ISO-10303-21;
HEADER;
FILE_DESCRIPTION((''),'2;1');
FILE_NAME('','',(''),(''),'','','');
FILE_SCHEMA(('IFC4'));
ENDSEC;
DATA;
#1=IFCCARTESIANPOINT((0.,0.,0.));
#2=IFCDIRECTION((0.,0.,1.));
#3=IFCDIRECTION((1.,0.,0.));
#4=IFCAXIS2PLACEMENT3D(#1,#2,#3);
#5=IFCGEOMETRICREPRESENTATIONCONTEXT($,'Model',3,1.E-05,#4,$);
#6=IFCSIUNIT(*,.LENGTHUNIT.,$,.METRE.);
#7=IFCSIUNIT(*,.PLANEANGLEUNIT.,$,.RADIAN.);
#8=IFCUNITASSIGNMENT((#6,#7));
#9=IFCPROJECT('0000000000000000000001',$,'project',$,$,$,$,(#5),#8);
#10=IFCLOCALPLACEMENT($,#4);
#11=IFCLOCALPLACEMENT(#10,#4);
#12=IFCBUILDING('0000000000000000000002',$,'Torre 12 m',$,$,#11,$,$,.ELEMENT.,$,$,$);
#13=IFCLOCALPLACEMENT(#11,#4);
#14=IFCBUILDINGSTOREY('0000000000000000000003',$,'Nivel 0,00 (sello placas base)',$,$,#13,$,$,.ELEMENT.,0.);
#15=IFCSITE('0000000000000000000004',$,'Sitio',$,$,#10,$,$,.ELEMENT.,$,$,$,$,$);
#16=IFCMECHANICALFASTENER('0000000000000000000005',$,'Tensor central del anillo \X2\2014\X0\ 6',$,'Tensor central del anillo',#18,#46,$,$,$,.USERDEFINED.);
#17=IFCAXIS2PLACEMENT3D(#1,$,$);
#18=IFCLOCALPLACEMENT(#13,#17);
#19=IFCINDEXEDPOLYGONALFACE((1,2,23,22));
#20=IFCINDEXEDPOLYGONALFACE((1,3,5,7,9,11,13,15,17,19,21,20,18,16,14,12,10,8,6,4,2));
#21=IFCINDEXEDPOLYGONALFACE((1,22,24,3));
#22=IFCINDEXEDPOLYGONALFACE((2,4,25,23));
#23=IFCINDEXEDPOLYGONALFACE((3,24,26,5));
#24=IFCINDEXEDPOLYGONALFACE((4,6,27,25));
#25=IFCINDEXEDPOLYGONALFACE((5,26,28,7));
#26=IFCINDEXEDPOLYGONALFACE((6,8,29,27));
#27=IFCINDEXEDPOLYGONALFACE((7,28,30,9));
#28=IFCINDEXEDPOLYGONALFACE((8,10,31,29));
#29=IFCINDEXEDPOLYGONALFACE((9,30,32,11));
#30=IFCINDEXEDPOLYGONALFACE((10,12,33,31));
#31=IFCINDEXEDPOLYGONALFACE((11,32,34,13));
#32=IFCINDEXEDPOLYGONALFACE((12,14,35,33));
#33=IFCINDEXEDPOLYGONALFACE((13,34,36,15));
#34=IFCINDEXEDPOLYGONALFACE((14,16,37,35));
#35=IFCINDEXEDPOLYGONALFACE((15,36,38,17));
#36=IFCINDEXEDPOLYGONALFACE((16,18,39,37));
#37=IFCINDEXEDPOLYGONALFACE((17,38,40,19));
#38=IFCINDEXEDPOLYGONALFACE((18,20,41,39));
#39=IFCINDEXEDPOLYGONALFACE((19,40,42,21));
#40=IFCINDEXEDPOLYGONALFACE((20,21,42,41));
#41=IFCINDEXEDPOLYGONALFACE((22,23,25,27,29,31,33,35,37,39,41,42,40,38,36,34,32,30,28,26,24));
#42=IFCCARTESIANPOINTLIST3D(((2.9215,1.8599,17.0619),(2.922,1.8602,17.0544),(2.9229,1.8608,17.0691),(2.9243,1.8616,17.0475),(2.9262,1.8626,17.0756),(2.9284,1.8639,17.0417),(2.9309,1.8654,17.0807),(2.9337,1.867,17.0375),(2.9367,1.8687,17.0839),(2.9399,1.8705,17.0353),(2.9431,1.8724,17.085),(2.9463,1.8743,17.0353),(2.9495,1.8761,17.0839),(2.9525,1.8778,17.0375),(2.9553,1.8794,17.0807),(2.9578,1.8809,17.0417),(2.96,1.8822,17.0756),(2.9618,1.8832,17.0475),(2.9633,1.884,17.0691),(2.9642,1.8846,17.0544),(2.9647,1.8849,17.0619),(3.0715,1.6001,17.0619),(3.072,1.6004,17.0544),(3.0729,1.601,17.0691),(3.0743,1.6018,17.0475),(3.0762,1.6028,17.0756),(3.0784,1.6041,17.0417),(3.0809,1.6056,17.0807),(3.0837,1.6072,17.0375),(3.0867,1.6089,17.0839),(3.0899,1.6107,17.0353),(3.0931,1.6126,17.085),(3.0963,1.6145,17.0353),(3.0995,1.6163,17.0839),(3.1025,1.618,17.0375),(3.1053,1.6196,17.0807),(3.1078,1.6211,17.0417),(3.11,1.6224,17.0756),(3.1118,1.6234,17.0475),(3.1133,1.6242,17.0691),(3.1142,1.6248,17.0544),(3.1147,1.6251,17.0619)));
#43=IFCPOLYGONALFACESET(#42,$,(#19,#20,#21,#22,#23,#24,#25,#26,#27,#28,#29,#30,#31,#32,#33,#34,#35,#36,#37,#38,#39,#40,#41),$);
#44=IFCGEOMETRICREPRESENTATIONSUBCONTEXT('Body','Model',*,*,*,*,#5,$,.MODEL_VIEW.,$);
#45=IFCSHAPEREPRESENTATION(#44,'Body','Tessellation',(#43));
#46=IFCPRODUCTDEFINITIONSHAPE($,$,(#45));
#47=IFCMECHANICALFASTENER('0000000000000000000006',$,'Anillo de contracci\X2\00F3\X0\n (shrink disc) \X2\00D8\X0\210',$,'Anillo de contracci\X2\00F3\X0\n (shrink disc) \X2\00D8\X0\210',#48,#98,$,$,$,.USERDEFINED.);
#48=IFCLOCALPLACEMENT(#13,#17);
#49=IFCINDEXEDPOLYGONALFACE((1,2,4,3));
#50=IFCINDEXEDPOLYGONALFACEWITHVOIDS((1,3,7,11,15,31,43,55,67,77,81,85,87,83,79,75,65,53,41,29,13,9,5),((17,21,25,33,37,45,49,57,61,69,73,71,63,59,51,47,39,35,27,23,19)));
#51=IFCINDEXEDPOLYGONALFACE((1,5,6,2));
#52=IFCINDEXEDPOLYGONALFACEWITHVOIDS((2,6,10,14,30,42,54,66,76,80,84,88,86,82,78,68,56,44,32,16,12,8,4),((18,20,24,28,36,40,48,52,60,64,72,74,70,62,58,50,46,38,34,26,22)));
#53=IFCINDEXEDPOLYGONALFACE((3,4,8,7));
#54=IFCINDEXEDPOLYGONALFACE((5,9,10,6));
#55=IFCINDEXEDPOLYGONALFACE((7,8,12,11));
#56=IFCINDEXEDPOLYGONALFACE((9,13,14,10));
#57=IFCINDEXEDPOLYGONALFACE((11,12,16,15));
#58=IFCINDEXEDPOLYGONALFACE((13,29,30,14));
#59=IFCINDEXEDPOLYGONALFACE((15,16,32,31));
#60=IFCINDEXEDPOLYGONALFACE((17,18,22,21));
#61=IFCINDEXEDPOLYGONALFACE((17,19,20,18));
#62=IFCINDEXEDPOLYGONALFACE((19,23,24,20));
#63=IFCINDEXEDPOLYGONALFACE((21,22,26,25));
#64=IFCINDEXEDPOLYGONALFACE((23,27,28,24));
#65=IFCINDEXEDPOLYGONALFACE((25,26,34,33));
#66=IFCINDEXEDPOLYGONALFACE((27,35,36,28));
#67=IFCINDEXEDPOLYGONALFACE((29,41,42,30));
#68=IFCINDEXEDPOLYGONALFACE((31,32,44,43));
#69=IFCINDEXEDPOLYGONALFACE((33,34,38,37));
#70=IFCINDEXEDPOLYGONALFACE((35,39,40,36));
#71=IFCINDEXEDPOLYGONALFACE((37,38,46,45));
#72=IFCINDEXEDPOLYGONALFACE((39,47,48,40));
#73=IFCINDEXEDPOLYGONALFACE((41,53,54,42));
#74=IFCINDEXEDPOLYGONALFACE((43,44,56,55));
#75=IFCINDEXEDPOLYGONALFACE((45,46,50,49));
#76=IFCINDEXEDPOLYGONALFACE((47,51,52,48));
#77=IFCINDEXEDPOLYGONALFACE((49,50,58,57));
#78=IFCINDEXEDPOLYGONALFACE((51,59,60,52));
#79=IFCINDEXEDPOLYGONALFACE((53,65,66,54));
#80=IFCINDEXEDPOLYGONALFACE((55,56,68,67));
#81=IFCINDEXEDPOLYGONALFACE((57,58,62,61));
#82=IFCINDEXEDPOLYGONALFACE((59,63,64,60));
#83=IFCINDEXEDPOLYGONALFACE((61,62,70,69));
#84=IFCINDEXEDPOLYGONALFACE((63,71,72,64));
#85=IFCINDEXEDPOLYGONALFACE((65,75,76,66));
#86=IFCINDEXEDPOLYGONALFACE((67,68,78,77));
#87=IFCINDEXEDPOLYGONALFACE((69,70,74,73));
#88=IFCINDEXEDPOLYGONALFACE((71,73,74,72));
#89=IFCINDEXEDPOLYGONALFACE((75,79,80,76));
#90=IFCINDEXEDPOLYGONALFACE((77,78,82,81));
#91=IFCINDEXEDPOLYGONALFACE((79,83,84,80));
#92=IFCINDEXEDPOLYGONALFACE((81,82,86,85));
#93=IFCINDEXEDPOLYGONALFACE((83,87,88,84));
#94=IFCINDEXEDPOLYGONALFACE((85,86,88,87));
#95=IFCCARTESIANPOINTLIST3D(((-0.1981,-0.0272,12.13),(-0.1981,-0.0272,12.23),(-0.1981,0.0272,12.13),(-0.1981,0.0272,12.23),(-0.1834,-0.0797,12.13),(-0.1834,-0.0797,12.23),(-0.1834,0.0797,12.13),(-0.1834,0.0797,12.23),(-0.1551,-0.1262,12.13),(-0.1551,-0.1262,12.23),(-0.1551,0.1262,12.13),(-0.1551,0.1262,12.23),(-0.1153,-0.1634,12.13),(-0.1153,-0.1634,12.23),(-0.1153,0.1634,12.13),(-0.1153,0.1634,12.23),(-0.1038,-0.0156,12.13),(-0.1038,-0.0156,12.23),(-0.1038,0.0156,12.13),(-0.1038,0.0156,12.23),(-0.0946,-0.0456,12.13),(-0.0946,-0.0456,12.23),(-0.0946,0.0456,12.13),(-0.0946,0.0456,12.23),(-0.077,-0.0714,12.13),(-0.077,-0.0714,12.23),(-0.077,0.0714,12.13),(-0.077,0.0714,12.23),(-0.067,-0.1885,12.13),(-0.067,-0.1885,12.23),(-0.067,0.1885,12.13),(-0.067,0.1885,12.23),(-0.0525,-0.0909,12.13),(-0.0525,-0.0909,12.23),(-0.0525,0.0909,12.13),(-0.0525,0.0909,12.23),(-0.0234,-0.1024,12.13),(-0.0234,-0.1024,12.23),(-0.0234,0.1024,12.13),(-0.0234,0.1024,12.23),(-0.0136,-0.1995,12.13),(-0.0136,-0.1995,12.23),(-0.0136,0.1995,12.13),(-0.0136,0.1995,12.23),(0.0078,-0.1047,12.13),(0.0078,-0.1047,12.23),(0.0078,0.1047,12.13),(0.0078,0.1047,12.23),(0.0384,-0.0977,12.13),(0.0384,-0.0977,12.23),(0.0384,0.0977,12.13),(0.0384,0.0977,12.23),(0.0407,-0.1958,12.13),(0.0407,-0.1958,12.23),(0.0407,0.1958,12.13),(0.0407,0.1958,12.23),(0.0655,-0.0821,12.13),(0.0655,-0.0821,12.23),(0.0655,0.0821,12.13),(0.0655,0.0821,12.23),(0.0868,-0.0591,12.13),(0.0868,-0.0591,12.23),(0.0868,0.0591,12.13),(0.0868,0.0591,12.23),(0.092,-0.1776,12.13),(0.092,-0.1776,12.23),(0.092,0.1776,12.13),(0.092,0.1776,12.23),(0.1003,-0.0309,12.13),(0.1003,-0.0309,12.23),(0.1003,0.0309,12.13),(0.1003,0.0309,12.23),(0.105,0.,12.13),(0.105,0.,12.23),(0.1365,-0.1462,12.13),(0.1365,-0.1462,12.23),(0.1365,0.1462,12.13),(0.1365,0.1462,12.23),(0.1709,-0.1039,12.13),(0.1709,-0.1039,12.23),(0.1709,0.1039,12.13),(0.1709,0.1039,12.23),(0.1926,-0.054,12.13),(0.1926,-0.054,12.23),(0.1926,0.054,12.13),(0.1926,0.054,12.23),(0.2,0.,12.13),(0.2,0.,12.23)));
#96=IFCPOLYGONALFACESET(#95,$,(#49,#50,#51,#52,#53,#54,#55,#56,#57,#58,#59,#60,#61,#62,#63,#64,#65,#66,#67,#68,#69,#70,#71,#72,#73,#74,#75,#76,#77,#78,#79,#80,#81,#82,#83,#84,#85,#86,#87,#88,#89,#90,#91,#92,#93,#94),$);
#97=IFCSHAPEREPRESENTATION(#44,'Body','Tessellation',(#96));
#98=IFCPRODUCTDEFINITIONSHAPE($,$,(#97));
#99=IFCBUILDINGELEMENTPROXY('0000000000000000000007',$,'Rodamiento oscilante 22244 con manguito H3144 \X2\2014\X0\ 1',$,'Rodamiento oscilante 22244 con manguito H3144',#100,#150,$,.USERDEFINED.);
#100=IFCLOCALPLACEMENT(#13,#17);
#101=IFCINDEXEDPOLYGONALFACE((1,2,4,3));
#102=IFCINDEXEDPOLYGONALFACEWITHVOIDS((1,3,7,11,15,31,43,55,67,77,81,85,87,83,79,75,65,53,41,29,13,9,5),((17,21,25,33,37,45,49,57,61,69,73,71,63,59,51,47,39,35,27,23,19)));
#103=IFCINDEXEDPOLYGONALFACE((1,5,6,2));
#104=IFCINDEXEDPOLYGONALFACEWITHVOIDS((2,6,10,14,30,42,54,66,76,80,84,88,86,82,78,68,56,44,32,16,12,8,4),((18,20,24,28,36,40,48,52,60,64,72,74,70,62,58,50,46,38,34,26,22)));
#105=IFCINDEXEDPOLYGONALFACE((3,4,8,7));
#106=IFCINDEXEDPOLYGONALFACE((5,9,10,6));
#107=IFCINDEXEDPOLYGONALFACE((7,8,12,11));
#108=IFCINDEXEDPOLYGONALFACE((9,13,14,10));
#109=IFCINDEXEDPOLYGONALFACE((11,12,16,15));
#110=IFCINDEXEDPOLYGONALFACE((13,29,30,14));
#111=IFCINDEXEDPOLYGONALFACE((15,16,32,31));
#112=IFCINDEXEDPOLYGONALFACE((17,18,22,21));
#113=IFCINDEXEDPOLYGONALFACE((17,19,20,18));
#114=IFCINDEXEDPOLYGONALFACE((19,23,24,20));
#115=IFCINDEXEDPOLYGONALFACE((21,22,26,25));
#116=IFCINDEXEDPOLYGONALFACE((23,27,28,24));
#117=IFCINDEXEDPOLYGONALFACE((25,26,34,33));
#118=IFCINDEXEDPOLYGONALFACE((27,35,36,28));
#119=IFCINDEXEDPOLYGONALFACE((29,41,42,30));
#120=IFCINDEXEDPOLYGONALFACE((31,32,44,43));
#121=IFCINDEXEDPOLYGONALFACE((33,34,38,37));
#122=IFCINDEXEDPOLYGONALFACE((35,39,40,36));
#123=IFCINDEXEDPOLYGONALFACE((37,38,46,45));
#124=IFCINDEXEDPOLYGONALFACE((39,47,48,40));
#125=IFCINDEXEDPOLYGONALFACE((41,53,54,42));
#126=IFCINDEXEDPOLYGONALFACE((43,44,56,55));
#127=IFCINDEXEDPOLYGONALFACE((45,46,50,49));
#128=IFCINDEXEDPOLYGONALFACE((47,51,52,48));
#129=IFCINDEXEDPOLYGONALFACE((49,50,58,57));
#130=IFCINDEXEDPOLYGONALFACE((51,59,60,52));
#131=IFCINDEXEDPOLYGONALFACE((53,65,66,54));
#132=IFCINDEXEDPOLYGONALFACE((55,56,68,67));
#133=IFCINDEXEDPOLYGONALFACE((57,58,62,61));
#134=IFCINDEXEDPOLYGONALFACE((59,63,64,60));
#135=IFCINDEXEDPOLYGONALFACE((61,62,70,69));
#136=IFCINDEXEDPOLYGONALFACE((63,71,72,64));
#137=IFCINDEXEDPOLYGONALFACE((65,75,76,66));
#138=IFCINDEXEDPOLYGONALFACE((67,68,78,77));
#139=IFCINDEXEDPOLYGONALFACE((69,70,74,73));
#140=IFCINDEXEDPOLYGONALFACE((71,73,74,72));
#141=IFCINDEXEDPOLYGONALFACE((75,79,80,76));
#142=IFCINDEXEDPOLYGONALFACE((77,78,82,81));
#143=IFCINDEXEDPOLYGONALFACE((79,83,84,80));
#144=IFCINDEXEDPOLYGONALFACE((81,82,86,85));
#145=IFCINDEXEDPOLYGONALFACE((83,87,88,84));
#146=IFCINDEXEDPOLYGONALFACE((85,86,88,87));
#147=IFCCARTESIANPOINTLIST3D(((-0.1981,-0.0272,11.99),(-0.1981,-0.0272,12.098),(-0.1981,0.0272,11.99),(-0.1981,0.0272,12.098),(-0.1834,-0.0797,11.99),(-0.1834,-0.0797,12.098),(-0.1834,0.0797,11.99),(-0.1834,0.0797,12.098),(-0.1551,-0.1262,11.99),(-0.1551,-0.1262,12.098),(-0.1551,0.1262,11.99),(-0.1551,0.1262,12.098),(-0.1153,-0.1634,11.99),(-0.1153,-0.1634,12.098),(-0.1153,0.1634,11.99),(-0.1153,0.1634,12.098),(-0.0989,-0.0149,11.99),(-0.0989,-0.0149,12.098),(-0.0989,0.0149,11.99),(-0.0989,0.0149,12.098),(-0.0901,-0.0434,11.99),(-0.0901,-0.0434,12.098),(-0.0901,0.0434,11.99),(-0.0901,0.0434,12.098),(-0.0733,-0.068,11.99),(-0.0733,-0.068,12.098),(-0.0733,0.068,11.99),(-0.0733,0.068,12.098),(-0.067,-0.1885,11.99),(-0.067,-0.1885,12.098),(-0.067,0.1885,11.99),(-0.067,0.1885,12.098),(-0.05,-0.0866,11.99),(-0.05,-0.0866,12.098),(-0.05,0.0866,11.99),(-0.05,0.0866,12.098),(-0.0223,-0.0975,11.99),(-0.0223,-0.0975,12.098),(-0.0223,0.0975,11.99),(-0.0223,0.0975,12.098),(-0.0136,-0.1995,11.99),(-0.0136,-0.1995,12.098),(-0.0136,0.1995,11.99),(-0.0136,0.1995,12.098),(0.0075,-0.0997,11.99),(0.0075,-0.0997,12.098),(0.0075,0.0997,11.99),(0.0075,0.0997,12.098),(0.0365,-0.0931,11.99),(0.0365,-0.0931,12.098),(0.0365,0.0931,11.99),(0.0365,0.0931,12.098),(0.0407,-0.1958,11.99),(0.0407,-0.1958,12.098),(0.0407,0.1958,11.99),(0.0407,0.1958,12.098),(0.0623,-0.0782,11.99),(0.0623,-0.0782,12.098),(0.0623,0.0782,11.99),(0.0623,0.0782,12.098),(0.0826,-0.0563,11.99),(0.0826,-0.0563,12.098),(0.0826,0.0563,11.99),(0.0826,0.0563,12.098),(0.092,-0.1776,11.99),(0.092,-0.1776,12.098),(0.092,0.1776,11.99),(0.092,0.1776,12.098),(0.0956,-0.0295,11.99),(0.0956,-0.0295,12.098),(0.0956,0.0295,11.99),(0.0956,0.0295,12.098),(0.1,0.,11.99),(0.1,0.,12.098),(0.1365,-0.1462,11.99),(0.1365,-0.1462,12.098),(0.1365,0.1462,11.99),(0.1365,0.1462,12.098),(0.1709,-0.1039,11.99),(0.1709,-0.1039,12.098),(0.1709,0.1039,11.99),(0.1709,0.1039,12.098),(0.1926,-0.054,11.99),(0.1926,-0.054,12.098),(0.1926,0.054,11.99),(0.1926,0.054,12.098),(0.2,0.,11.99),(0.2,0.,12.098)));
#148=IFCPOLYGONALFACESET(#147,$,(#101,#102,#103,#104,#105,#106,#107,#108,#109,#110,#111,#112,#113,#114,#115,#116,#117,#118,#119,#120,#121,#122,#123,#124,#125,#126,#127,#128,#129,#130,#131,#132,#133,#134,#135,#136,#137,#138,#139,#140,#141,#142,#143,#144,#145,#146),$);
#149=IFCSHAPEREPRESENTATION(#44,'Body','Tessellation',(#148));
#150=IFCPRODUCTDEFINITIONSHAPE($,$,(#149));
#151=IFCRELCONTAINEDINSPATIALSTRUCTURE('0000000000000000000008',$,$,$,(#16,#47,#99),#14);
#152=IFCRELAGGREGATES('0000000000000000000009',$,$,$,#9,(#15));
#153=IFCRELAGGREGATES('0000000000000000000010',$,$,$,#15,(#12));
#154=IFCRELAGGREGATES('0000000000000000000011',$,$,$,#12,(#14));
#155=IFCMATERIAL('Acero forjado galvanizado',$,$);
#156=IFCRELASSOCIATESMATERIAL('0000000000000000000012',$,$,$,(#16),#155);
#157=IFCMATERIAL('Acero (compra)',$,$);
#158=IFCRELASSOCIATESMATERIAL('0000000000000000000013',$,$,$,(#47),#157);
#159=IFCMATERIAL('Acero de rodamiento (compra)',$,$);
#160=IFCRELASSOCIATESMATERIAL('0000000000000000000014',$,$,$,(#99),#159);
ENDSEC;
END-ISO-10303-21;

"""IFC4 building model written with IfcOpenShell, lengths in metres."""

from ifc_helpers import new_model, si_unit, frame, origin, origin_with_axes, origin_2d, place, context, subcontext, project, spatial, circle, hollow_circle, extrude, material, element, save


model = new_model("IFC4")

# Units and contexts
model_context = context("Model", 3, precision=1e-05, world=origin_with_axes())
body_context = subcontext(model_context, "Body", "Model", "MODEL_VIEW")
ifc_project = project(units=[si_unit("LENGTHUNIT", "METRE"), si_unit("PLANEANGLEUNIT", "RADIAN")], contexts=[model_context])

# Site, building, storey
site_placement = place(None, origin_with_axes())
site = spatial("IfcSite", under=ifc_project, at=site_placement, Name="Sitio", CompositionType="ELEMENT")
building_placement = place(site_placement, origin_with_axes())
building = spatial("IfcBuilding", under=site, at=building_placement, Name="Torre 12 m", CompositionType="ELEMENT")
storey_placement = place(building_placement, origin_with_axes())
storey = spatial("IfcBuildingStorey", under=building, at=storey_placement, Name="Nivel 0,00 (sello placas base)", CompositionType="ELEMENT", Elevation=0.0)

# Mechanical fasteners
ifc_material_1 = material(Name="Acero forjado galvanizado")
for number, where, z_axis, x_axis, name in (
    (1, (3.0931, 1.6126, 17.06), (-0.5, 0.866025, 0.0), (0.0, 0.0, 1.0), "Tensor central del anillo — 6"),
):
    element("IfcMechanicalFastener", number, at=place(storey_placement, frame(where, z_axis=z_axis, x_axis=x_axis)), inside=storey, material=ifc_material_1, Name=name, ObjectType="Tensor central del anillo", PredefinedType="USERDEFINED", context=body_context, shape_type="SweptSolid", body=[
        extrude(circle(Radius=0.025, at=origin_2d()), origin(), (0.0, 0.0, 1.0), 0.3),
    ])
ifc_material_2 = material(Name="Acero (compra)")
mechanical_fastener_placement = place(storey_placement, frame((0.0, 0.0, 12.13), z_axis=(0.0, 0.0, 1.0), x_axis=(1.0, 0.0, 0.0)))
element("IfcMechanicalFastener", 2, at=mechanical_fastener_placement, inside=storey, material=ifc_material_2, Name="Anillo de contracción (shrink disc) Ø210", ObjectType="Anillo de contracción (shrink disc) Ø210", PredefinedType="USERDEFINED", context=body_context, shape_type="SweptSolid", body=[
    extrude(hollow_circle(Radius=0.2, WallThickness=0.095, at=origin_2d()), origin(), (0.0, 0.0, 1.0), 0.1),
])

# Building element proxy
ifc_material_3 = material(Name="Acero de rodamiento (compra)")
proxy_placement = place(storey_placement, frame((0.0, 0.0, 11.99), z_axis=(0.0, 0.0, 1.0), x_axis=(1.0, 0.0, 0.0)))
element("IfcBuildingElementProxy", 3, at=proxy_placement, inside=storey, material=ifc_material_3, Name="Rodamiento oscilante 22244 con manguito H3144 — 1", ObjectType="Rodamiento oscilante 22244 con manguito H3144", PredefinedType="USERDEFINED", context=body_context, shape_type="SweptSolid", body=[
    extrude(hollow_circle(Radius=0.2, WallThickness=0.1, at=origin_2d()), origin(), (0.0, 0.0, 1.0), 0.108),
])

save(model, "model.ifc")
